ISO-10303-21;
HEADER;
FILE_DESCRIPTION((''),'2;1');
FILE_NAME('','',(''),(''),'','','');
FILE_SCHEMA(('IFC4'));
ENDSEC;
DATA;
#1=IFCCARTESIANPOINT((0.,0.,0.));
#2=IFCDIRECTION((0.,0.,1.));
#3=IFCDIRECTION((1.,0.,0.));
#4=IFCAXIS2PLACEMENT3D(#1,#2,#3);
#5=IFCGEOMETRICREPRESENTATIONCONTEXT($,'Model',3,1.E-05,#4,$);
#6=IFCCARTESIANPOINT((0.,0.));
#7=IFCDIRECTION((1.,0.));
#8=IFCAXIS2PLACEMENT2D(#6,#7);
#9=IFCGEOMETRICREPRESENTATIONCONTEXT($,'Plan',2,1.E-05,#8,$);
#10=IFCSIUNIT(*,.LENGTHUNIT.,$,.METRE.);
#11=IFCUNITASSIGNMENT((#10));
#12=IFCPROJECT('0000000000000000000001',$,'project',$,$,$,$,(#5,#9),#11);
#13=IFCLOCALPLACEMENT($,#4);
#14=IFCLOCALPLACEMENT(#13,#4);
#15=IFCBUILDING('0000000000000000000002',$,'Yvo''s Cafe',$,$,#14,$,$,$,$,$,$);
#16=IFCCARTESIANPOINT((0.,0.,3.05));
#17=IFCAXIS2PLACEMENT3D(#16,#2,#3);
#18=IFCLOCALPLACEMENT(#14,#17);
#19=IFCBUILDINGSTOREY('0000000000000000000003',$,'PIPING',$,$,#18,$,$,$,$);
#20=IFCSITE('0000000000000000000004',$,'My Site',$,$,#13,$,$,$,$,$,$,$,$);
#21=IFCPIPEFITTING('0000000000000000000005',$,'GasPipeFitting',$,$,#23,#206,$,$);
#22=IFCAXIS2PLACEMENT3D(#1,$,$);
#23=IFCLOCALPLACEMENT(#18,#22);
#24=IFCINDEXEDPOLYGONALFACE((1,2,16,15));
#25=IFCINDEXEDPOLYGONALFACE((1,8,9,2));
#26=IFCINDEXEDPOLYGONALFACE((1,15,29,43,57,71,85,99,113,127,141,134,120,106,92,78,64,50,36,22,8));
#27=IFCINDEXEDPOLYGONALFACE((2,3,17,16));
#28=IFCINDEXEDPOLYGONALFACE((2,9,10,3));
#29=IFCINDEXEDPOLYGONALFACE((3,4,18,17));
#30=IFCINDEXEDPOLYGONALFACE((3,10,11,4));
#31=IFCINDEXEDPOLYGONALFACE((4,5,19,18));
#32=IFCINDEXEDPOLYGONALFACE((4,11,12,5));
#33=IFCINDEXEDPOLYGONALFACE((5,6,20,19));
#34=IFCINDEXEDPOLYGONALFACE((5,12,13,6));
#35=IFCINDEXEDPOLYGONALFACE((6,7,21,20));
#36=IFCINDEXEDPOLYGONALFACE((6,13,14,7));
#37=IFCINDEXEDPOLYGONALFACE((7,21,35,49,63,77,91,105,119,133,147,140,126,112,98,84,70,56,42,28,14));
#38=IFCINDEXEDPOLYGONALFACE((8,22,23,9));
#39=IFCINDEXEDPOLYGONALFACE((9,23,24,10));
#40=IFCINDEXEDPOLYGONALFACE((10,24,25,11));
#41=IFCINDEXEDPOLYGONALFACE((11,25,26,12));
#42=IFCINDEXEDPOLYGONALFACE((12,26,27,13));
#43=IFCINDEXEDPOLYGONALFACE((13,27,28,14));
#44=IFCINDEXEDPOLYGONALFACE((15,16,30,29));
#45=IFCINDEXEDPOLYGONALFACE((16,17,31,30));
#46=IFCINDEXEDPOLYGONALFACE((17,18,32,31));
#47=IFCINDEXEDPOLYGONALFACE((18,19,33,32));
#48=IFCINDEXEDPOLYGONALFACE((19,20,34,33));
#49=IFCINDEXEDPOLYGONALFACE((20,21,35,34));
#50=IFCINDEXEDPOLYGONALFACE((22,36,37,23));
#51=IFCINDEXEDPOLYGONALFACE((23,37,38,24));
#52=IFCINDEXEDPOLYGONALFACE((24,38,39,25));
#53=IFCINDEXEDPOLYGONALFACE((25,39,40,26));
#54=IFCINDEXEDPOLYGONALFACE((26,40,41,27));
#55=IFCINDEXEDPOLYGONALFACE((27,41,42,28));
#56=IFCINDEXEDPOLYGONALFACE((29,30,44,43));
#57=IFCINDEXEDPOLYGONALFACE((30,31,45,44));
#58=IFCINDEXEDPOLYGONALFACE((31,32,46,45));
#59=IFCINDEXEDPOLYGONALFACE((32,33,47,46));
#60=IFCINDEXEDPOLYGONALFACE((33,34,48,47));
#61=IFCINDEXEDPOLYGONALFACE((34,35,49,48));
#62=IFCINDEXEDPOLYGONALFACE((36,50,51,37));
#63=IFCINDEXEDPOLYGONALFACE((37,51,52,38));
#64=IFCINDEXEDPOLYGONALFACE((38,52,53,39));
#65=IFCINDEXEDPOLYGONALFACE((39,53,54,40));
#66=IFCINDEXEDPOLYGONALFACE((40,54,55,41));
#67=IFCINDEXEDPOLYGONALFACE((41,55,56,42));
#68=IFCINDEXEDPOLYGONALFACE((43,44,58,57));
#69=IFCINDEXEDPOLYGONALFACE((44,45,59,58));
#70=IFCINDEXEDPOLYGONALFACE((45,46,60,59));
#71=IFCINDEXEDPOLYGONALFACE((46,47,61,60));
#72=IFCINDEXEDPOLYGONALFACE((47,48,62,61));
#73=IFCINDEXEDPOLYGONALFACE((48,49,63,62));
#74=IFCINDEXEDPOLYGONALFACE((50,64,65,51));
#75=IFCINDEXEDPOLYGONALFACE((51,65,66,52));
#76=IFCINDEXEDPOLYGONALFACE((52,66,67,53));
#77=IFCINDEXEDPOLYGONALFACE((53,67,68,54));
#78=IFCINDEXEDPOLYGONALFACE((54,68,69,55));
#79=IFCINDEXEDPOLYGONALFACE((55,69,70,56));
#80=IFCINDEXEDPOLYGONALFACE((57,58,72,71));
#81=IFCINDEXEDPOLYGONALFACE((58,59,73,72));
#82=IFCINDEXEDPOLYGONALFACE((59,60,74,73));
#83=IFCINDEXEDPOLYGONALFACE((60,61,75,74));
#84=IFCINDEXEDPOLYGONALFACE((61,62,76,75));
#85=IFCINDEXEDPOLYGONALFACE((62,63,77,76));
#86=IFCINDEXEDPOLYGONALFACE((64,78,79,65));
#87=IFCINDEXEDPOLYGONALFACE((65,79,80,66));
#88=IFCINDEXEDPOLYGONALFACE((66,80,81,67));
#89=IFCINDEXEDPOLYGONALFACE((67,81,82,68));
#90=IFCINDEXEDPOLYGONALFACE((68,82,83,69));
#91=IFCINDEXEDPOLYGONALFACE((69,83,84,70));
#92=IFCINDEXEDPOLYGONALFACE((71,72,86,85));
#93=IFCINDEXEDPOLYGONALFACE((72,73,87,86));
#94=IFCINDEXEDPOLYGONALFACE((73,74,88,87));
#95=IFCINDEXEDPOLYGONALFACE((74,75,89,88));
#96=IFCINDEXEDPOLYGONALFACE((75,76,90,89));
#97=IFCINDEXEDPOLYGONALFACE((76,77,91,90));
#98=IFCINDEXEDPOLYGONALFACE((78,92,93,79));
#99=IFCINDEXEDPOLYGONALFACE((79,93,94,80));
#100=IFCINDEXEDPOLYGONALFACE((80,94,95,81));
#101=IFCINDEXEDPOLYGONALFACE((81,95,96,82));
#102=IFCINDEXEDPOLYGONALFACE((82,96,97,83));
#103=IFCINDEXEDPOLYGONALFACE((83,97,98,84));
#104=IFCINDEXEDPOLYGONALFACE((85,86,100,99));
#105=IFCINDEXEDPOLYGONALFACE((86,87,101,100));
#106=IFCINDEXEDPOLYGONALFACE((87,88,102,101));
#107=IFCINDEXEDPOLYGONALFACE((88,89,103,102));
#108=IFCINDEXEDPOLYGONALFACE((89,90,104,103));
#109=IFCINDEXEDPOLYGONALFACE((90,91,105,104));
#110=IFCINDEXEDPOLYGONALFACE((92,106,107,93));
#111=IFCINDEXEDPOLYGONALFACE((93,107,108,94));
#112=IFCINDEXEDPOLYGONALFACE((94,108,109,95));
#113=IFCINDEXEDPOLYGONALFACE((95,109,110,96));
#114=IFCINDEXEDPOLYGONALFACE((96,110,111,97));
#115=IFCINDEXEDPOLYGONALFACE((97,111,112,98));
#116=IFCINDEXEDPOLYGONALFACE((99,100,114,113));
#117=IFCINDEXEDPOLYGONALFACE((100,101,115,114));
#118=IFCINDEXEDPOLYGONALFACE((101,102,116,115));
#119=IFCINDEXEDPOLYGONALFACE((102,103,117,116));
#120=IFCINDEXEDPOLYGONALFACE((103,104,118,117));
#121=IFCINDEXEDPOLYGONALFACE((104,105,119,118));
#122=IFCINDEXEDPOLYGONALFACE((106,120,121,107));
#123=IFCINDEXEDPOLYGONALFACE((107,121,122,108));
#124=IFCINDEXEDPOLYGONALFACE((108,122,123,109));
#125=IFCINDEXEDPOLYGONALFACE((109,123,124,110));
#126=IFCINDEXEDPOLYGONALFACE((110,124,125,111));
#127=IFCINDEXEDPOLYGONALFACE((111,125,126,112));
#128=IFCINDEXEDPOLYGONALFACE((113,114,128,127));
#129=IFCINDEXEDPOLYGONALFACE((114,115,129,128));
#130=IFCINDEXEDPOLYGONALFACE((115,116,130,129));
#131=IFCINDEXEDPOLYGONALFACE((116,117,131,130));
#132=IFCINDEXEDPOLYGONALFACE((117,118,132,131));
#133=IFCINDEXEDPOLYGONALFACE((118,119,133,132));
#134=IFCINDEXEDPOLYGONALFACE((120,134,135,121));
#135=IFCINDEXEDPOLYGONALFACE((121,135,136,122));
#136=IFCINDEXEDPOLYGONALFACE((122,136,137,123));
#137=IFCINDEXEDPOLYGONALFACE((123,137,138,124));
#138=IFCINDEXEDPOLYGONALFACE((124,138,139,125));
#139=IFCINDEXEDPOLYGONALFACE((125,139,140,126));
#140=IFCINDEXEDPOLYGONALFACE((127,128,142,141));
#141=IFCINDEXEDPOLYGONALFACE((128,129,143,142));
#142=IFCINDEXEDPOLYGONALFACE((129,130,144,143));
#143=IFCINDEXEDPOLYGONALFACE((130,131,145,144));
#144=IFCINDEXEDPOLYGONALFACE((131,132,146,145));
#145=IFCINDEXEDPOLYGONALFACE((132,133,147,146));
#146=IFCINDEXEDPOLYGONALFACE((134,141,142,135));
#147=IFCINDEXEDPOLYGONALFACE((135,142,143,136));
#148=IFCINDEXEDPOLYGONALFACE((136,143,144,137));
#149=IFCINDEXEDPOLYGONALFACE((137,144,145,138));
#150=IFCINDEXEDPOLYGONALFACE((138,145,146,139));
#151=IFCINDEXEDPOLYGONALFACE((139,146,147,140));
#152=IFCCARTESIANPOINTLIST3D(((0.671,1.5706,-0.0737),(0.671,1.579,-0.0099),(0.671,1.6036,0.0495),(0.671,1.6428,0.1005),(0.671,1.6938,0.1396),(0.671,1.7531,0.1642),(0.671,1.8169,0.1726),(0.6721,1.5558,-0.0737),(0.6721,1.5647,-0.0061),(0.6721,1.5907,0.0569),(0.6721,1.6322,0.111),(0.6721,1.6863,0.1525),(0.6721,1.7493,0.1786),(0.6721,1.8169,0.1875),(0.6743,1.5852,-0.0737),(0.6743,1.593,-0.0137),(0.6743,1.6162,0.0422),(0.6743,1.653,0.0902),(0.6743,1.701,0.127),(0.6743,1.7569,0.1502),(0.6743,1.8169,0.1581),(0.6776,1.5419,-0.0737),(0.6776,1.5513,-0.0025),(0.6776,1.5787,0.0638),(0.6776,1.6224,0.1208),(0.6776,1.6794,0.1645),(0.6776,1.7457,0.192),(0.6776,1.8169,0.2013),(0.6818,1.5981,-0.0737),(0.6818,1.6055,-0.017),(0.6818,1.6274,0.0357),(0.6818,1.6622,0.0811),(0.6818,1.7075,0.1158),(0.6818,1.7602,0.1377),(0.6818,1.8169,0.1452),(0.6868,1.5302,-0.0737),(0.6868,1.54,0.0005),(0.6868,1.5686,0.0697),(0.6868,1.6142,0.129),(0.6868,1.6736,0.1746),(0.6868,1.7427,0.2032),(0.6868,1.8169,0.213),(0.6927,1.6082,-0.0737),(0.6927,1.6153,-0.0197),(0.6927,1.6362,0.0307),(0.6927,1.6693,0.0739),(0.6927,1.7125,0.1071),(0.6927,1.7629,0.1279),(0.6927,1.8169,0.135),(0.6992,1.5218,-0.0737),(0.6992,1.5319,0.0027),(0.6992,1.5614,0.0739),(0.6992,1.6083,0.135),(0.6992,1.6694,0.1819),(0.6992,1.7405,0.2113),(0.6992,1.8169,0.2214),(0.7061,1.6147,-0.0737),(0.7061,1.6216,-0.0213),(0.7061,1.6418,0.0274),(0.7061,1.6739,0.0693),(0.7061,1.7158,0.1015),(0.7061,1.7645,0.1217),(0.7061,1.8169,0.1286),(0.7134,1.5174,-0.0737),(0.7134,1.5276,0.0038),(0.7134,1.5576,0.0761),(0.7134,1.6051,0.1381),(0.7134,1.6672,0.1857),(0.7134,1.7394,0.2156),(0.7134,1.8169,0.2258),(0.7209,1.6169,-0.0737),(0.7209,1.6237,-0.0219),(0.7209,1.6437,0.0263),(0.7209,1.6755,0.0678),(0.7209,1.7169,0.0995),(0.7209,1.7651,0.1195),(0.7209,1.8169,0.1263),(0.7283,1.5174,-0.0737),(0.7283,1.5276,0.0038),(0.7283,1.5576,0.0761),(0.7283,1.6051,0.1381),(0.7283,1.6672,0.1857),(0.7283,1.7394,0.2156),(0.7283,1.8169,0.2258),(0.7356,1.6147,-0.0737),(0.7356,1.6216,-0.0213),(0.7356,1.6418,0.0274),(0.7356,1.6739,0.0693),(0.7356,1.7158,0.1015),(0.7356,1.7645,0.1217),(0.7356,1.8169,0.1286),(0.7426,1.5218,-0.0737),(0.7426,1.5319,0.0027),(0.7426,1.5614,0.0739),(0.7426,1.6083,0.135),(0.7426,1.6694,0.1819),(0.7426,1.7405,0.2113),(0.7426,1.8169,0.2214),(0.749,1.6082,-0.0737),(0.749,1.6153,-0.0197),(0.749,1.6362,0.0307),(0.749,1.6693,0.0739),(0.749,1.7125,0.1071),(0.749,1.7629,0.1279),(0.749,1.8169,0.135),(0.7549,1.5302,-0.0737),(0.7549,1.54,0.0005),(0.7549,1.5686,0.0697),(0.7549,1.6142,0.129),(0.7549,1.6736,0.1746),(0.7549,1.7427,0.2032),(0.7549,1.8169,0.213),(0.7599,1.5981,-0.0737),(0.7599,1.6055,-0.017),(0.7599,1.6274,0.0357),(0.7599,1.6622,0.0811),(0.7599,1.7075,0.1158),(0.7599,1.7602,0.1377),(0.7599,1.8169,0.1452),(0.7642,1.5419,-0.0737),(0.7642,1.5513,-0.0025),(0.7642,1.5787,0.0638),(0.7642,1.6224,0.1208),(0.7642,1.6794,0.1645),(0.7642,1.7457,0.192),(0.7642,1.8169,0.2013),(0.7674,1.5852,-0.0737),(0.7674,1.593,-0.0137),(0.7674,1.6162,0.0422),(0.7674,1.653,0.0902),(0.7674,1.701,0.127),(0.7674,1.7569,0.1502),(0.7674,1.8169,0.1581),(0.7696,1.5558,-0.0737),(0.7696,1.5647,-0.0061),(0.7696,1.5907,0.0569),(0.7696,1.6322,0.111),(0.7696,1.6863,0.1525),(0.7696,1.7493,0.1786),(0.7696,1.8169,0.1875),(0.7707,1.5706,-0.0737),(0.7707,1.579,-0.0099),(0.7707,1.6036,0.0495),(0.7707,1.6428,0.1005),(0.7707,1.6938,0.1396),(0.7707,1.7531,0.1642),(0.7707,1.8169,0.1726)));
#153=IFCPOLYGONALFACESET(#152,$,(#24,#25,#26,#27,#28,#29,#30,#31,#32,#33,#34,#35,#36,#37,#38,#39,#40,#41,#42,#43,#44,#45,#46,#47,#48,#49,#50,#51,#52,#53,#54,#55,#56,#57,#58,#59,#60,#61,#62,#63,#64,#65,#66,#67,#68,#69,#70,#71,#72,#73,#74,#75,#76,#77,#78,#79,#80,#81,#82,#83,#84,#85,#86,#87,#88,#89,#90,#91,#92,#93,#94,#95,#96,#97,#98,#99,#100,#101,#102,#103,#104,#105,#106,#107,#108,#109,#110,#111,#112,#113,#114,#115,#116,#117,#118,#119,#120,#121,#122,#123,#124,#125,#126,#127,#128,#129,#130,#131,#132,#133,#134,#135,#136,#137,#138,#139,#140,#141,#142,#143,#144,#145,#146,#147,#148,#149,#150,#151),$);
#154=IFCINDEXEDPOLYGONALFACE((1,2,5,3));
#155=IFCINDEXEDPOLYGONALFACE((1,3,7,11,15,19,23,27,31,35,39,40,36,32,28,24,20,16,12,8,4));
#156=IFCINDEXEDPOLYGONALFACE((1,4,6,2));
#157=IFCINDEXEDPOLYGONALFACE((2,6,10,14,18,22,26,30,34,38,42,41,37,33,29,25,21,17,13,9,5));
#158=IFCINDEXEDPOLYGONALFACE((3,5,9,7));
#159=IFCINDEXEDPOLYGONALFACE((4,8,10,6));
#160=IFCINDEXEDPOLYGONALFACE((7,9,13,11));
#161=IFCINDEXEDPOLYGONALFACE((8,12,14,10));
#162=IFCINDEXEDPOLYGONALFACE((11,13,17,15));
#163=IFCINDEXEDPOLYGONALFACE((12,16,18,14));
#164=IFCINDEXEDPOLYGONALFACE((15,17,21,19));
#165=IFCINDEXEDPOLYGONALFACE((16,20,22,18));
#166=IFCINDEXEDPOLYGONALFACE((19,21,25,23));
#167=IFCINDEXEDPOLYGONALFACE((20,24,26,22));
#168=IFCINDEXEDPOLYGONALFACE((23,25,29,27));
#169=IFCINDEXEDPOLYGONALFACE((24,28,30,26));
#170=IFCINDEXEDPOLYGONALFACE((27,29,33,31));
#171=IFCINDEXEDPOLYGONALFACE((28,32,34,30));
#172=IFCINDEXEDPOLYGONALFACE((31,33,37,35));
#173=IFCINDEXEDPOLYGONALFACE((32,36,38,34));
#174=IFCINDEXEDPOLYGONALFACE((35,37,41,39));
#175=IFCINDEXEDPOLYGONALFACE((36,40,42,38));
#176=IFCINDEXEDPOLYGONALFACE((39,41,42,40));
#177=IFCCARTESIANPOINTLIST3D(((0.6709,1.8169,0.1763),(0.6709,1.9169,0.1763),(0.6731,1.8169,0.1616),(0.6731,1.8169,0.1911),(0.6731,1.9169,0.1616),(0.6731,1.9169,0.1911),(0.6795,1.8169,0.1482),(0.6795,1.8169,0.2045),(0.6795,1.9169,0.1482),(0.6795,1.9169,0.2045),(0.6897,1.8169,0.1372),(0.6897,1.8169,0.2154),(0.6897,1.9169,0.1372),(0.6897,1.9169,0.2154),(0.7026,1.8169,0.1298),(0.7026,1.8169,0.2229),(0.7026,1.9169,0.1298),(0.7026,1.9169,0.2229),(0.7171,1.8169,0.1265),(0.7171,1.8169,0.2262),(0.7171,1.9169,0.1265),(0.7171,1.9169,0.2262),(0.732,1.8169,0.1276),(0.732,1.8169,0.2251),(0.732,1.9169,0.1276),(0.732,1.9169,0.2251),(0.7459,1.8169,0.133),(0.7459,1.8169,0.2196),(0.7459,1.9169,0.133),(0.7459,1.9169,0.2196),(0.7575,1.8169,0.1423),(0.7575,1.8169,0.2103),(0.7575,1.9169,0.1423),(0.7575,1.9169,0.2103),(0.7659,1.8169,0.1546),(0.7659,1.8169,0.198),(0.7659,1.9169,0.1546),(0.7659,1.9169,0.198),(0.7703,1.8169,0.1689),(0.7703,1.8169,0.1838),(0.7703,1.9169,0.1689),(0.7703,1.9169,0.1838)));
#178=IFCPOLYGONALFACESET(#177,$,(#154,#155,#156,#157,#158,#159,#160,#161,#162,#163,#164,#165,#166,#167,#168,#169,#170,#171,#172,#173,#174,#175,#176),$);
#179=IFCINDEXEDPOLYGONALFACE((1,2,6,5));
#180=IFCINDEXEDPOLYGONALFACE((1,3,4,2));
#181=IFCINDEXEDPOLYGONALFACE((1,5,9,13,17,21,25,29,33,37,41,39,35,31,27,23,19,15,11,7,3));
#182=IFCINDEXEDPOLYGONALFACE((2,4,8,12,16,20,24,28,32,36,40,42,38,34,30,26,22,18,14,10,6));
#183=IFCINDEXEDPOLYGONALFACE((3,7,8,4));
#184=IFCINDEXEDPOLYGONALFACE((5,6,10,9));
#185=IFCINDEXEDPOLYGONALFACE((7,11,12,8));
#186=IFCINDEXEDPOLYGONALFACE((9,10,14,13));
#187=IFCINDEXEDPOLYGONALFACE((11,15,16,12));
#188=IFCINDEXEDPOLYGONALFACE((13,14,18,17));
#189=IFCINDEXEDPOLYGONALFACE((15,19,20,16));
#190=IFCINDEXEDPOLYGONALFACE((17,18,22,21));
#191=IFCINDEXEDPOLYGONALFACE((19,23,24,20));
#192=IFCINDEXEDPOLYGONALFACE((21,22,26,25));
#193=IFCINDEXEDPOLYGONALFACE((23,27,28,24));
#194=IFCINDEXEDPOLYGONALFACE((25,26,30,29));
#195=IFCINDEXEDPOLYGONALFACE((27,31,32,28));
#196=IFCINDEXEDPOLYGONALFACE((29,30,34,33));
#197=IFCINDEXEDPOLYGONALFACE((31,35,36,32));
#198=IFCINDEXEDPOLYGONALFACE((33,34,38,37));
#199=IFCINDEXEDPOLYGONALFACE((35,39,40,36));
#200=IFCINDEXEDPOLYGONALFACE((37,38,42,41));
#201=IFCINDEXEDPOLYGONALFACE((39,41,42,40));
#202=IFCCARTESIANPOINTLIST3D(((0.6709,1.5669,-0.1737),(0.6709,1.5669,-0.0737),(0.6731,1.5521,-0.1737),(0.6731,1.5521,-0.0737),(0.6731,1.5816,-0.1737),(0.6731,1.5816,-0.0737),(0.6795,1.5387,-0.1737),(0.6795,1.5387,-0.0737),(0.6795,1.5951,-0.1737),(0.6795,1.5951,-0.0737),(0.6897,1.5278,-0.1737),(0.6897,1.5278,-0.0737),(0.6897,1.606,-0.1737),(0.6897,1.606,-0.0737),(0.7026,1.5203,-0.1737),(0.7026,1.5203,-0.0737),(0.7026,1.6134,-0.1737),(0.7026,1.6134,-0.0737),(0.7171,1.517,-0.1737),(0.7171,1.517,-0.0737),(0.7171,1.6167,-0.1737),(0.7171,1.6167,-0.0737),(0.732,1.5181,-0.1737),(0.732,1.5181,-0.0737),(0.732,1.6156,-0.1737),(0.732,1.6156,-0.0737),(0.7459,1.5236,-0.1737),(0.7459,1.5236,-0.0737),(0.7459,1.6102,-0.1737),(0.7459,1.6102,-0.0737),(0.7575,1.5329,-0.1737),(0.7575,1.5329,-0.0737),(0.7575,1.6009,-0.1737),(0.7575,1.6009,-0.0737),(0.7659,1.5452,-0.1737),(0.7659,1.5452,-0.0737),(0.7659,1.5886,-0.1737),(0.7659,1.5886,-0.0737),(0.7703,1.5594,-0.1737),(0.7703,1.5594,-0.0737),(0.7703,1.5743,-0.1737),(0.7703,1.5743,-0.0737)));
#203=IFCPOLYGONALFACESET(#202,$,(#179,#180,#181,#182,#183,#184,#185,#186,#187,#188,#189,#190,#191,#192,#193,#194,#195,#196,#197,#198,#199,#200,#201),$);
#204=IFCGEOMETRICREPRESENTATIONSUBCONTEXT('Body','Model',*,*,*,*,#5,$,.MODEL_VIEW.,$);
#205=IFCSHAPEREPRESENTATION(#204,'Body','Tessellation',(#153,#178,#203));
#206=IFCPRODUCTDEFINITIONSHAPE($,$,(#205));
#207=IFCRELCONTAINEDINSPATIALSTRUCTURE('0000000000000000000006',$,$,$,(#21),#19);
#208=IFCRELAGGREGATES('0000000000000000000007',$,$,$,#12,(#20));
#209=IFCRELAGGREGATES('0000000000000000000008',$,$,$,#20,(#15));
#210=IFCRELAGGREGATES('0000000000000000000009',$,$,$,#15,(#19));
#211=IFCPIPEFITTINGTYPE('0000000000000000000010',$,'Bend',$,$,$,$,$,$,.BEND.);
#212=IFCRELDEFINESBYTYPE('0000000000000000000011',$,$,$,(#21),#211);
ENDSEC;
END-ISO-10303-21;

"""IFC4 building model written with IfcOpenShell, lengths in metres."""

from ifc_helpers import new_model, entity, si_unit, frame, origin_with_axes, origin_2d_with_axis, place, context, subcontext, project, spatial, circle, extrude, source, transform, mapped, type_object, type_shapes, element, save


model = new_model("IFC4")

# Units and contexts
model_context = context("Model", 3, precision=1e-05, world=origin_with_axes())
plan_context = context("Plan", 2, precision=1e-05, world=origin_2d_with_axis())
body_context = subcontext(model_context, "Body", "Model", "MODEL_VIEW")
ifc_project = project(units=[si_unit("LENGTHUNIT", "METRE")], contexts=[model_context, plan_context])

# Site, building, storey
site_placement = place(None, origin_with_axes())
site = spatial("IfcSite", under=ifc_project, at=site_placement, Name="My Site")
building_placement = place(site_placement, origin_with_axes())
building = spatial("IfcBuilding", under=site, at=building_placement, Name="Yvo's Cafe")
storey_placement = place(building_placement, frame((0.0, 0.0, 3.05), z_axis=(0.0, 0.0, 1.0), x_axis=(1.0, 0.0, 0.0)))
storey = spatial("IfcBuildingStorey", under=building, at=storey_placement, Name="PIPING")

# Shared definitions
pipe_fitting_type_1 = type_object("IfcPipeFittingType", Name="Bend", PredefinedType="BEND")
shared_shape_1 = source(origin_with_axes(), body_context, "Body", "SolidModel", [
    entity("IfcSweptDiskSolid", entity("IfcIndexedPolyCurve", entity("IfcCartesianPointList3D", [[0.0, 0.0, -0.1], [0.0, -0.0732, -0.2768], [0.0, -0.25, -0.35]]), [entity("IfcArcIndex", [1, 2, 3])]), 0.05),
    extrude(circle(Radius=0.05), origin_with_axes(), (0.0, 0.0, -1.0), 0.1),
    extrude(circle(Radius=0.05), frame((0.0, -0.25, -0.35), z_axis=(0.0, -1.0, 0.0), x_axis=(1.0, 0.0, 0.0)), (0.0, 0.0, 1.0), 0.1),
])
type_shapes(pipe_fitting_type_1, [shared_shape_1])

# Pipe fitting
for number, where, z_axis, x_axis, name in (
    (1, (0.7209, 1.9169, 0.1763), (0.0, 1.0, 0.0), (-1.0, 0.0, 0.0), "GasPipeFitting"),
):
    element("IfcPipeFitting", number, at=place(storey_placement, frame(where, z_axis=z_axis, x_axis=x_axis)), inside=storey, type_object=pipe_fitting_type_1, Name=name, context=body_context, shape_type="MappedRepresentation", body=[
        mapped(shared_shape_1, transform((0.0, 0.0, 0.0), x_axis=(1.0, 0.0, 0.0), y_axis=(0.0, 1.0, 0.0), z_axis=(0.0, 0.0, 1.0), scale=1.0)),
    ])

save(model, "model.ifc")
